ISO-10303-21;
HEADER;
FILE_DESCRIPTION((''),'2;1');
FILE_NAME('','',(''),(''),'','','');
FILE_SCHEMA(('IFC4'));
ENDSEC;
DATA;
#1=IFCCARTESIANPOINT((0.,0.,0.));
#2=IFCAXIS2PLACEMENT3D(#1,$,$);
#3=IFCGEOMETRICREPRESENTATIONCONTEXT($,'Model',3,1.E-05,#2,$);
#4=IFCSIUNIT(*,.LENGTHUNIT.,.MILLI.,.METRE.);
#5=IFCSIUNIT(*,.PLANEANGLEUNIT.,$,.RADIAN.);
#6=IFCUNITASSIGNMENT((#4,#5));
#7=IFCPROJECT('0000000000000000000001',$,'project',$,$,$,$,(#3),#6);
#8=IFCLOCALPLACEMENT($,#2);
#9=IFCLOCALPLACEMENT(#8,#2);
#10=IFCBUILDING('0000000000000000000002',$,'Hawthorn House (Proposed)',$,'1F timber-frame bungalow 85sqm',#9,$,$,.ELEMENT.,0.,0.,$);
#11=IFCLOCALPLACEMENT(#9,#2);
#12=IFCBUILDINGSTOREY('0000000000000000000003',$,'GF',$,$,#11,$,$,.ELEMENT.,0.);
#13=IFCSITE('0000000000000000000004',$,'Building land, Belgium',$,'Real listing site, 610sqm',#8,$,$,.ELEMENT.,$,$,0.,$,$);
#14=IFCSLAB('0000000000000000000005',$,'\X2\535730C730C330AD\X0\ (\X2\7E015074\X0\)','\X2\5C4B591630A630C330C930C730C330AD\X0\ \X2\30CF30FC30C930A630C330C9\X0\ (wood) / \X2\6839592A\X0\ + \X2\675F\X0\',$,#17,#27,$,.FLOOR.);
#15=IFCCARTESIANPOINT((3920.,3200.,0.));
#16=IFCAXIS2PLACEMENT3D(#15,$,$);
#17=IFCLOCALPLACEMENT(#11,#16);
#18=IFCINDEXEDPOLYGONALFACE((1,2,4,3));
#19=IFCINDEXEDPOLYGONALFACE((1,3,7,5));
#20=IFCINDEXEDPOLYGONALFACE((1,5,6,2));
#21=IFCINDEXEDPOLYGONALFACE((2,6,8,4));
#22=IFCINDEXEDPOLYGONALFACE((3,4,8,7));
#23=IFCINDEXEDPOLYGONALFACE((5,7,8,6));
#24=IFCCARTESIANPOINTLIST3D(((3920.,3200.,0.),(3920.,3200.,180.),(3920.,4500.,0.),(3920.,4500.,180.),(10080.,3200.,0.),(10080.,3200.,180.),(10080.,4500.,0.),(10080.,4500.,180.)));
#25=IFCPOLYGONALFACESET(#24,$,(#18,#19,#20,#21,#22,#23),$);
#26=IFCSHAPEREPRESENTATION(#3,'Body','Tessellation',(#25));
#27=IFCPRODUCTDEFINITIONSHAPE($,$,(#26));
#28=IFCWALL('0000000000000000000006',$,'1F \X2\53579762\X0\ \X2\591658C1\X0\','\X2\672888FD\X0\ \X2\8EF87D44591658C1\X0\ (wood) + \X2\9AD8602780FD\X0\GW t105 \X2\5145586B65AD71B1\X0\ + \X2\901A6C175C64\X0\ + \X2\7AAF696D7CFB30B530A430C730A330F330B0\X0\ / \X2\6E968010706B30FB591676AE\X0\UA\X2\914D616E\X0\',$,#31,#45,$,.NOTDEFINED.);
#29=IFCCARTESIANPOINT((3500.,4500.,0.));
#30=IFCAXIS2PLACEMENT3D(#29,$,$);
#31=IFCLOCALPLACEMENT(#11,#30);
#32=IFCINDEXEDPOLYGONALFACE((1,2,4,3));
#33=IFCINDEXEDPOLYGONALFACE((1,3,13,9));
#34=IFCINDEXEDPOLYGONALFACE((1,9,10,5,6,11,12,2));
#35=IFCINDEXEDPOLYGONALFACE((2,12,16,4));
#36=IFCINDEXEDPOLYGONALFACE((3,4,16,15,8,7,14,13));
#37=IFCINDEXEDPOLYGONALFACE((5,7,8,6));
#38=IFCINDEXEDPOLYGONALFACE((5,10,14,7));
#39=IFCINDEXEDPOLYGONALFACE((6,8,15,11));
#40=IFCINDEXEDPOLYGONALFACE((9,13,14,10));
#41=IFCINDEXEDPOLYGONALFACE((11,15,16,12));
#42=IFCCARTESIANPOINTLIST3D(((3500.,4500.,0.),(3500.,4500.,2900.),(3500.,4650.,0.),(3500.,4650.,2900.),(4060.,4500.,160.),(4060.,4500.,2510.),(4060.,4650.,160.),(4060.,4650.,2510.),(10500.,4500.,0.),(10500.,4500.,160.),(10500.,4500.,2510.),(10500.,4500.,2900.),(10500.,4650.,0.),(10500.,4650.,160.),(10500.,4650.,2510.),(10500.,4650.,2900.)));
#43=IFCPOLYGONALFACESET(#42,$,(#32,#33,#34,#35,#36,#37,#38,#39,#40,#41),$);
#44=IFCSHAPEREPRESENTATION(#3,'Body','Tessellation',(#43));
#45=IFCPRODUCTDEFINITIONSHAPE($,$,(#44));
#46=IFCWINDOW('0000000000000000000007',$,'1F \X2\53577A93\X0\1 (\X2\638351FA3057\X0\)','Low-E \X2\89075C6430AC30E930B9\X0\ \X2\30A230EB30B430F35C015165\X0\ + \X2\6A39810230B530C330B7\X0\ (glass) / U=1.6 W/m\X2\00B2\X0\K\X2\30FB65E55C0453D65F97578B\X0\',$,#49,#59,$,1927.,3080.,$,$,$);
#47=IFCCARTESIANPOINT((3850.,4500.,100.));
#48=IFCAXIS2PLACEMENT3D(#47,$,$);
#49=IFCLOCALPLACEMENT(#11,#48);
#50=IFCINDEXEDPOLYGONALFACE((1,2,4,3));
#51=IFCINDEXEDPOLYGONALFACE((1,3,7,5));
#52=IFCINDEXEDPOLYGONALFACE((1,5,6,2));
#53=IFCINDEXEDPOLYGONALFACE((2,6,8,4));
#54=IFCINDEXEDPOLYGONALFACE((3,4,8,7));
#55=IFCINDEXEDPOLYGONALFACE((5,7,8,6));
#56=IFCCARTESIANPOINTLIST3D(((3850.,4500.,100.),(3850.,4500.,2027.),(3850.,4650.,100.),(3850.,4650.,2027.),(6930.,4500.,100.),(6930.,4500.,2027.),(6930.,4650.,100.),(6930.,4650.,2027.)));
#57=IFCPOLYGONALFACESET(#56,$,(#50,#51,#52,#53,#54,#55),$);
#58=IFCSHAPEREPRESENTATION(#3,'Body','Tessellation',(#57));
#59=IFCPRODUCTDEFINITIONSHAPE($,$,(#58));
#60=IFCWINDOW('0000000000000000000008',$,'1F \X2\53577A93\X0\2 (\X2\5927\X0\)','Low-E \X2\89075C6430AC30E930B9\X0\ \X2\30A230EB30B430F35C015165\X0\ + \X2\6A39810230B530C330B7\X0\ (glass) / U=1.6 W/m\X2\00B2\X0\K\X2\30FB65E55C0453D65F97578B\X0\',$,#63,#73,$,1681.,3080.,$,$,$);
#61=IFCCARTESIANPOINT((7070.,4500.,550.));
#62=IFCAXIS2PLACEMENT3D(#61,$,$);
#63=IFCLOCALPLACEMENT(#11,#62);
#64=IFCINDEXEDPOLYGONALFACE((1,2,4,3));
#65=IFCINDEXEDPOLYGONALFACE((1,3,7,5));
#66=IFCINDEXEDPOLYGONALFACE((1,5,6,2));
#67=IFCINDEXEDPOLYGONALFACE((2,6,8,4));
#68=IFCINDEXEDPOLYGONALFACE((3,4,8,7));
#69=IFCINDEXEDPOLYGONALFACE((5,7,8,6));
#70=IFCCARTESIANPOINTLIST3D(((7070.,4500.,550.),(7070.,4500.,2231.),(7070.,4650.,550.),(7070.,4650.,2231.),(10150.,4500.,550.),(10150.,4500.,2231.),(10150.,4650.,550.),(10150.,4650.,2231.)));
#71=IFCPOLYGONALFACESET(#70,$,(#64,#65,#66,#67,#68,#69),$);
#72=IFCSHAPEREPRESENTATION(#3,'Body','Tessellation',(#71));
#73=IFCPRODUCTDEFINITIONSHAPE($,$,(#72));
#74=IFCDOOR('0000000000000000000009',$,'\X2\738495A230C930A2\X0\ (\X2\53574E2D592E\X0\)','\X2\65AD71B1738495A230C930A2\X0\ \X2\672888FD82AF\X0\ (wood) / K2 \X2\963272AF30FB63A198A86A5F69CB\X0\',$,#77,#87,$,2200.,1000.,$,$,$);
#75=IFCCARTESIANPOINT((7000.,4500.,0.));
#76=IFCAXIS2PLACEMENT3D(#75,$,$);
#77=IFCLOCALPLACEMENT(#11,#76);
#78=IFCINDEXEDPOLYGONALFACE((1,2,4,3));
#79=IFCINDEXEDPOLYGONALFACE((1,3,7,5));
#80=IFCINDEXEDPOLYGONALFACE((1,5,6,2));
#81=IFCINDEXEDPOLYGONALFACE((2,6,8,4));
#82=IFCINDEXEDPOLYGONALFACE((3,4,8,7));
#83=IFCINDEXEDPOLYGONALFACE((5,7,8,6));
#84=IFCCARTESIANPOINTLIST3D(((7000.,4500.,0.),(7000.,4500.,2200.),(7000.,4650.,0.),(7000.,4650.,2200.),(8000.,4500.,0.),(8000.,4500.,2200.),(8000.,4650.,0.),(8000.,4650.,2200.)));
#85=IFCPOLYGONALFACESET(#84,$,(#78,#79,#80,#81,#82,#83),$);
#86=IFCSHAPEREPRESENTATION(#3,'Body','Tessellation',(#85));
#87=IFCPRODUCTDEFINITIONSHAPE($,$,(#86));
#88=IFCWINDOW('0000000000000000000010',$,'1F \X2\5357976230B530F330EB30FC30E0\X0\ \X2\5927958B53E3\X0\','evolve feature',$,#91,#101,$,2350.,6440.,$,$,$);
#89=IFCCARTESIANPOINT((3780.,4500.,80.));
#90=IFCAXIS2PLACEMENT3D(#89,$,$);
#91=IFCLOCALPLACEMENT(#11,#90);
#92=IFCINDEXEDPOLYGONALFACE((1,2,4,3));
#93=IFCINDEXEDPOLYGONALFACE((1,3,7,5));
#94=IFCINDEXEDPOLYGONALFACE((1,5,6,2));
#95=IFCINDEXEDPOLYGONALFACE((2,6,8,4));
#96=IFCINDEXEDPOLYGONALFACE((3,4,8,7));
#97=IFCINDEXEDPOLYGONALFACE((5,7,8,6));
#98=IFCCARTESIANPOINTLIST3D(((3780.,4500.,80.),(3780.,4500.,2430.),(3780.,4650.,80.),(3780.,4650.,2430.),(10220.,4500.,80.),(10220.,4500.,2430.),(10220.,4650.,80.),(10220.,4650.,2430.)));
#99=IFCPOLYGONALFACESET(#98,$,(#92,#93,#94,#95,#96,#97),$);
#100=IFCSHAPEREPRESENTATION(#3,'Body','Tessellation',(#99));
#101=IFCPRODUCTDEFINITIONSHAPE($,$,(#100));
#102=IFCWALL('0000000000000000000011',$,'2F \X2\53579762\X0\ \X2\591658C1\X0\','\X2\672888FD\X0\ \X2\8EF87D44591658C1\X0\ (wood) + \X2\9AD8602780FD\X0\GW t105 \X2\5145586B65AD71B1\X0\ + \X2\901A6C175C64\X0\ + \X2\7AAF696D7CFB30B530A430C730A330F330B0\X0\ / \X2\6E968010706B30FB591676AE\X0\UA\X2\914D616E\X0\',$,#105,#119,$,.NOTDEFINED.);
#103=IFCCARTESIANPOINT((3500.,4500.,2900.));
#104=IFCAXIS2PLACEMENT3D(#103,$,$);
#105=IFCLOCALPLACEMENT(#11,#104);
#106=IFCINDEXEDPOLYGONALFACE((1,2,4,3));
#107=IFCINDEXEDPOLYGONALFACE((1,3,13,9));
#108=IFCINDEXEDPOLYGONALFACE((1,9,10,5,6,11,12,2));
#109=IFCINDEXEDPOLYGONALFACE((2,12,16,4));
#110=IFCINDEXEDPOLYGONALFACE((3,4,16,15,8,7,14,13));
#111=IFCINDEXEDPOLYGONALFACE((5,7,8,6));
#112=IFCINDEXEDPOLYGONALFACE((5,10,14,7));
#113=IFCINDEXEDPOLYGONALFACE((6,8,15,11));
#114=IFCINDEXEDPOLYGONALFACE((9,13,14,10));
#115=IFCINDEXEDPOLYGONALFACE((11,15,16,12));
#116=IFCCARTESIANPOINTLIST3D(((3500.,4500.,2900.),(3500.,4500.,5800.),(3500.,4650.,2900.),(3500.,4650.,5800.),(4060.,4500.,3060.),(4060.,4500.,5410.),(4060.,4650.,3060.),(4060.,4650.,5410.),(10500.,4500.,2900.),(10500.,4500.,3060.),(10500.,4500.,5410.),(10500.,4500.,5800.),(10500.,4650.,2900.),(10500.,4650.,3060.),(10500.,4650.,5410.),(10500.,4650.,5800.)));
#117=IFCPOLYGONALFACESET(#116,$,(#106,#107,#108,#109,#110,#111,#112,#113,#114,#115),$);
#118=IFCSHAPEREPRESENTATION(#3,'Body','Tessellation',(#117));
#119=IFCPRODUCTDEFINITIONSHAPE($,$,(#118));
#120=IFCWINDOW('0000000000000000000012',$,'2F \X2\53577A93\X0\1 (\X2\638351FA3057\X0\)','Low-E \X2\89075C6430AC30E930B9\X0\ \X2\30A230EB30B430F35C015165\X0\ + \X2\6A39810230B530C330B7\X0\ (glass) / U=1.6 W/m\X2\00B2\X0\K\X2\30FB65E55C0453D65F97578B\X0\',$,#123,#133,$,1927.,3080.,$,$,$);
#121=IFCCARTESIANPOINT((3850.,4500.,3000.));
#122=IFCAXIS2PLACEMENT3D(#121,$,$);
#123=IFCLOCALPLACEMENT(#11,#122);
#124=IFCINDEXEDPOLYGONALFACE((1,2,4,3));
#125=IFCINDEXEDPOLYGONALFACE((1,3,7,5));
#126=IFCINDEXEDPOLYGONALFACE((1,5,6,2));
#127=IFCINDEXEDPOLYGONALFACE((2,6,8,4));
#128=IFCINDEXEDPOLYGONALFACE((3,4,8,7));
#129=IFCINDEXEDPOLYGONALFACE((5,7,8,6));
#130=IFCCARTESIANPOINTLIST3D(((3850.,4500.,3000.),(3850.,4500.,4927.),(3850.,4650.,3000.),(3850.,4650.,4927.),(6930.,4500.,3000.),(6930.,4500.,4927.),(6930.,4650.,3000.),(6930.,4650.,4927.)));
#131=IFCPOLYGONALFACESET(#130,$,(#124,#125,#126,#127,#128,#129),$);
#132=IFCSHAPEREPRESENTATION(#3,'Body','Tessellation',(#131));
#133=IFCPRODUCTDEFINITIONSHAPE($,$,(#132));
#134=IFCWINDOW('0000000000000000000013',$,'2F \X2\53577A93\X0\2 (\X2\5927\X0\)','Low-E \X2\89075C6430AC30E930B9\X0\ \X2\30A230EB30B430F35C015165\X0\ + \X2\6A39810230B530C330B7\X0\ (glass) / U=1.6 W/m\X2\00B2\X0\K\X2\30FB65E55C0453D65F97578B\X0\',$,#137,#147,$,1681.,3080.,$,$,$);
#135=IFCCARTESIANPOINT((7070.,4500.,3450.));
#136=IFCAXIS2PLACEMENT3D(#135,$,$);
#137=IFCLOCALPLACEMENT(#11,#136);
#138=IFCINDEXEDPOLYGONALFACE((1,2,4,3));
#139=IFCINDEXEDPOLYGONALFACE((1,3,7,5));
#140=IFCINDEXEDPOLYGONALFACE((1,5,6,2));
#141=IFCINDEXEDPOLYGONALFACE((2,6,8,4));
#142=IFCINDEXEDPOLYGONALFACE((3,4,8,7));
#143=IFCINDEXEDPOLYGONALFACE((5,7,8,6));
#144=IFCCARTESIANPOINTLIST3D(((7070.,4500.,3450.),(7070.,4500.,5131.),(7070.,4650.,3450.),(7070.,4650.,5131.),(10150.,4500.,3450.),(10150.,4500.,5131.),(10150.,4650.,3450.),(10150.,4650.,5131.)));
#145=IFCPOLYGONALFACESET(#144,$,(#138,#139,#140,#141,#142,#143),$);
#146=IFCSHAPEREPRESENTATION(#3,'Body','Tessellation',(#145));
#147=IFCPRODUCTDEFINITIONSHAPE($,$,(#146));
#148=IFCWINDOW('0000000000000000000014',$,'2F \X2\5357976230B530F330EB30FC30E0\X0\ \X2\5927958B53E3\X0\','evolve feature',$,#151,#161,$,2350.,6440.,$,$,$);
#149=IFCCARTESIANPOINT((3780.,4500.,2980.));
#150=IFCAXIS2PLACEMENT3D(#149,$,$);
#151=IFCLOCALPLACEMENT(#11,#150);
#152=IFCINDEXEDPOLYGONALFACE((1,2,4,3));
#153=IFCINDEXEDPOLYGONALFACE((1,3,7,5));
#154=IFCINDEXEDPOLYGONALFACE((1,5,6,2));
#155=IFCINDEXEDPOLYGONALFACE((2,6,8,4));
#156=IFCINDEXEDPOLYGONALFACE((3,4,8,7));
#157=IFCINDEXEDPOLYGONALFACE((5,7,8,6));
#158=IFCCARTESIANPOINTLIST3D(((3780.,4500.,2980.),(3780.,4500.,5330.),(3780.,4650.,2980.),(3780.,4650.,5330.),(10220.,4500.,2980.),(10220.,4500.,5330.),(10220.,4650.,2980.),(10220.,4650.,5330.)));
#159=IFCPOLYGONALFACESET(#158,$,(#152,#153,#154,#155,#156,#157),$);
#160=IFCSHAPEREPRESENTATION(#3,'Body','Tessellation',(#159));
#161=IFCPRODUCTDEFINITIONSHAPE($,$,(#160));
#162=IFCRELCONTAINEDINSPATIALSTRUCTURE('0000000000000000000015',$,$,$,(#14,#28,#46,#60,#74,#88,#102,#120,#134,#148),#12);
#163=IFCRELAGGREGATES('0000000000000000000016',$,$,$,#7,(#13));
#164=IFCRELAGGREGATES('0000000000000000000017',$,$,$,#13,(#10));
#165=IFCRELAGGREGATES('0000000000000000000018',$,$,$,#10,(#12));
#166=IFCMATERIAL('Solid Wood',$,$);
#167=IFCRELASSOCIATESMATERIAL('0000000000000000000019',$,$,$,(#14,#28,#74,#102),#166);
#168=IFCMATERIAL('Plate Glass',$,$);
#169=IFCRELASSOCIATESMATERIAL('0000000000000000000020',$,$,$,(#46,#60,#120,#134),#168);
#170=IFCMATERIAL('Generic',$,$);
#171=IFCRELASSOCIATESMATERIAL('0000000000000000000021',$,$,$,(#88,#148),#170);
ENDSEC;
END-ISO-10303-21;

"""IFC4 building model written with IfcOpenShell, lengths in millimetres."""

from ifc_helpers import new_model, si_unit, frame, frame_2d, origin, place, context, project, spatial, rectangle, extrude, material, element, fill, save


model = new_model("IFC4")

# Units and contexts
model_context = context("Model", 3, precision=1e-05, world=origin())
ifc_project = project(units=[si_unit("LENGTHUNIT", "METRE", prefix="MILLI"), si_unit("PLANEANGLEUNIT", "RADIAN")], contexts=[model_context])

# Site, building, storey
site_placement = place(None, origin())
site = spatial("IfcSite", under=ifc_project, at=site_placement, Name="Building land, Belgium", ObjectType="Real listing site, 610sqm", CompositionType="ELEMENT", RefElevation=0.0)
building_placement = place(site_placement, origin())
building = spatial("IfcBuilding", under=site, at=building_placement, Name="Hawthorn House (Proposed)", ObjectType="1F timber-frame bungalow 85sqm", CompositionType="ELEMENT", ElevationOfRefHeight=0.0, ElevationOfTerrain=0.0)
storey_placement = place(building_placement, origin())
storey = spatial("IfcBuildingStorey", under=building, at=storey_placement, Name="GF", CompositionType="ELEMENT", Elevation=0.0)

# Slab
ifc_material_1 = material(Name="Solid Wood")
slab_1_placement = place(storey_placement, frame((3920.0, 3200.0, 0.0)))
element("IfcSlab", 1, at=slab_1_placement, inside=storey, material=ifc_material_1, Name="南デッキ (縁側)", Description="屋外ウッドデッキ ハードウッド (wood) / 根太 + 束", PredefinedType="FLOOR", context=model_context, shape_type="SweptSolid", body=[
    extrude(rectangle(XDim=6160.0, YDim=1300.0, at=frame_2d((3080.0, 650.0))), frame((3920.0, 3200.0, 0.0)), (0.0, 0.0, 1.0), 180.0),
])
ifc_material_2 = material(Name="Generic")

# Wall, openings, windows, door
wall_1_placement = place(storey_placement, frame((3500.0, 4500.0, 0.0)))
wall_1 = element("IfcWall", 2, at=wall_1_placement, inside=storey, material=ifc_material_1, Name="1F 南面 外壁", Description="木製 軸組外壁 (wood) + 高性能GW t105 充填断熱 + 通気層 + 窯業系サイディング / 準耐火・外皮UA配慮", PredefinedType="NOTDEFINED", context=model_context, shape_type="SweptSolid", body=[
    extrude(rectangle(XDim=7000.0, YDim=150.0, at=frame_2d((3500.0, 75.0))), frame((3500.0, 4500.0, 0.0)), (0.0, 0.0, 1.0), 2900.0),
])
opening_1_placement = place(storey_placement, frame((3850.0, 4500.0, 100.0)))
opening_1 = element("IfcOpeningElement", 3, at=opening_1_placement, cuts=wall_1, PredefinedType="NOTDEFINED", context=model_context, shape_type="SweptSolid", body=[
    extrude(rectangle(XDim=3080.0, YDim=150.0, at=frame_2d((1540.0, 75.0))), frame((3850.0, 4500.0, 100.0)), (0.0, 0.0, 1.0), 1927.0),
])
opening_2_placement = place(storey_placement, frame((7070.0, 4500.0, 550.0)))
opening_2 = element("IfcOpeningElement", 4, at=opening_2_placement, cuts=wall_1, PredefinedType="NOTDEFINED", context=model_context, shape_type="SweptSolid", body=[
    extrude(rectangle(XDim=3080.0, YDim=150.0, at=frame_2d((1540.0, 75.0))), frame((7070.0, 4500.0, 550.0)), (0.0, 0.0, 1.0), 1681.0),
])
opening_3_placement = place(storey_placement, frame((7000.0, 4500.0, 0.0)))
opening_3 = element("IfcOpeningElement", 5, at=opening_3_placement, cuts=wall_1, PredefinedType="NOTDEFINED", context=model_context, shape_type="SweptSolid", body=[
    extrude(rectangle(XDim=1000.0, YDim=150.0, at=frame_2d((500.0, 75.0))), frame((7000.0, 4500.0, 0.0)), (0.0, 0.0, 1.0), 2200.0),
])
opening_4_placement = place(storey_placement, frame((3780.0, 4500.0, 80.0)))
opening_4 = element("IfcOpeningElement", 6, at=opening_4_placement, cuts=wall_1, PredefinedType="NOTDEFINED", context=model_context, shape_type="SweptSolid", body=[
    extrude(rectangle(XDim=6440.0, YDim=150.0, at=frame_2d((3220.0, 75.0))), frame((3780.0, 4500.0, 80.0)), (0.0, 0.0, 1.0), 2350.0),
])
ifc_material_3 = material(Name="Plate Glass")
window_1_placement = place(storey_placement, frame((3850.0, 4500.0, 100.0)))
window_1 = element("IfcWindow", 7, at=window_1_placement, inside=storey, material=ifc_material_3, Name="1F 南窓1 (掃出し)", Description="Low-E 複層ガラス アルゴン封入 + 樹脂サッシ (glass) / U=1.6 W/m²K・日射取得型", OverallHeight=1927.0, OverallWidth=3080.0, context=model_context, shape_type="SweptSolid", body=[
    extrude(rectangle(XDim=3080.0, YDim=150.0, at=frame_2d((1540.0, 75.0))), frame((3850.0, 4500.0, 100.0)), (0.0, 0.0, 1.0), 1927.0),
])
fill(opening_1, window_1)
window_2_placement = place(storey_placement, frame((7070.0, 4500.0, 550.0)))
window_2 = element("IfcWindow", 8, at=window_2_placement, inside=storey, material=ifc_material_3, Name="1F 南窓2 (大)", Description="Low-E 複層ガラス アルゴン封入 + 樹脂サッシ (glass) / U=1.6 W/m²K・日射取得型", OverallHeight=1681.0, OverallWidth=3080.0, context=model_context, shape_type="SweptSolid", body=[
    extrude(rectangle(XDim=3080.0, YDim=150.0, at=frame_2d((1540.0, 75.0))), frame((7070.0, 4500.0, 550.0)), (0.0, 0.0, 1.0), 1681.0),
])
fill(opening_2, window_2)
door_placement = place(storey_placement, frame((7000.0, 4500.0, 0.0)))
door = element("IfcDoor", 9, at=door_placement, inside=storey, material=ifc_material_1, Name="玄関ドア (南中央)", Description="断熱玄関ドア 木製芯 (wood) / K2 防犯・採風機構", OverallHeight=2200.0, OverallWidth=1000.0, context=model_context, shape_type="SweptSolid", body=[
    extrude(rectangle(XDim=1000.0, YDim=150.0, at=frame_2d((500.0, 75.0))), frame((7000.0, 4500.0, 0.0)), (0.0, 0.0, 1.0), 2200.0),
])
fill(opening_3, door)
window_3_placement = place(storey_placement, frame((3780.0, 4500.0, 80.0)))
window_3 = element("IfcWindow", 10, at=window_3_placement, inside=storey, material=ifc_material_2, Name="1F 南面サンルーム 大開口", Description="evolve feature", OverallHeight=2350.0, OverallWidth=6440.0, context=model_context, shape_type="SweptSolid", body=[
    extrude(rectangle(XDim=6440.0, YDim=150.0, at=frame_2d((3220.0, 75.0))), frame((3780.0, 4500.0, 80.0)), (0.0, 0.0, 1.0), 2350.0),
])
fill(opening_4, window_3)

# Wall, openings, windows
wall_2_placement = place(storey_placement, frame((3500.0, 4500.0, 2900.0)))
wall_2 = element("IfcWall", 11, at=wall_2_placement, inside=storey, material=ifc_material_1, Name="2F 南面 外壁", Description="木製 軸組外壁 (wood) + 高性能GW t105 充填断熱 + 通気層 + 窯業系サイディング / 準耐火・外皮UA配慮", PredefinedType="NOTDEFINED", context=model_context, shape_type="SweptSolid", body=[
    extrude(rectangle(XDim=7000.0, YDim=150.0, at=frame_2d((3500.0, 75.0))), frame((3500.0, 4500.0, 2900.0)), (0.0, 0.0, 1.0), 2900.0),
])
opening_5_placement = place(storey_placement, frame((3850.0, 4500.0, 3000.0)))
opening_5 = element("IfcOpeningElement", 12, at=opening_5_placement, cuts=wall_2, PredefinedType="NOTDEFINED", context=model_context, shape_type="SweptSolid", body=[
    extrude(rectangle(XDim=3080.0, YDim=150.0, at=frame_2d((1540.0, 75.0))), frame((3850.0, 4500.0, 3000.0)), (0.0, 0.0, 1.0), 1927.0),
])
opening_6_placement = place(storey_placement, frame((7070.0, 4500.0, 3450.0)))
opening_6 = element("IfcOpeningElement", 13, at=opening_6_placement, cuts=wall_2, PredefinedType="NOTDEFINED", context=model_context, shape_type="SweptSolid", body=[
    extrude(rectangle(XDim=3080.0, YDim=150.0, at=frame_2d((1540.0, 75.0))), frame((7070.0, 4500.0, 3450.0)), (0.0, 0.0, 1.0), 1681.0),
])
opening_7_placement = place(storey_placement, frame((3780.0, 4500.0, 2980.0)))
opening_7 = element("IfcOpeningElement", 14, at=opening_7_placement, cuts=wall_2, PredefinedType="NOTDEFINED", context=model_context, shape_type="SweptSolid", body=[
    extrude(rectangle(XDim=6440.0, YDim=150.0, at=frame_2d((3220.0, 75.0))), frame((3780.0, 4500.0, 2980.0)), (0.0, 0.0, 1.0), 2350.0),
])
window_4_placement = place(storey_placement, frame((3850.0, 4500.0, 3000.0)))
window_4 = element("IfcWindow", 15, at=window_4_placement, inside=storey, material=ifc_material_3, Name="2F 南窓1 (掃出し)", Description="Low-E 複層ガラス アルゴン封入 + 樹脂サッシ (glass) / U=1.6 W/m²K・日射取得型", OverallHeight=1927.0, OverallWidth=3080.0, context=model_context, shape_type="SweptSolid", body=[
    extrude(rectangle(XDim=3080.0, YDim=150.0, at=frame_2d((1540.0, 75.0))), frame((3850.0, 4500.0, 3000.0)), (0.0, 0.0, 1.0), 1927.0),
])
fill(opening_5, window_4)
window_5_placement = place(storey_placement, frame((7070.0, 4500.0, 3450.0)))
window_5 = element("IfcWindow", 16, at=window_5_placement, inside=storey, material=ifc_material_3, Name="2F 南窓2 (大)", Description="Low-E 複層ガラス アルゴン封入 + 樹脂サッシ (glass) / U=1.6 W/m²K・日射取得型", OverallHeight=1681.0, OverallWidth=3080.0, context=model_context, shape_type="SweptSolid", body=[
    extrude(rectangle(XDim=3080.0, YDim=150.0, at=frame_2d((1540.0, 75.0))), frame((7070.0, 4500.0, 3450.0)), (0.0, 0.0, 1.0), 1681.0),
])
fill(opening_6, window_5)
window_6_placement = place(storey_placement, frame((3780.0, 4500.0, 2980.0)))
window_6 = element("IfcWindow", 17, at=window_6_placement, inside=storey, material=ifc_material_2, Name="2F 南面サンルーム 大開口", Description="evolve feature", OverallHeight=2350.0, OverallWidth=6440.0, context=model_context, shape_type="SweptSolid", body=[
    extrude(rectangle(XDim=6440.0, YDim=150.0, at=frame_2d((3220.0, 75.0))), frame((3780.0, 4500.0, 2980.0)), (0.0, 0.0, 1.0), 2350.0),
])
fill(opening_7, window_6)

save(model, "model.ifc")
